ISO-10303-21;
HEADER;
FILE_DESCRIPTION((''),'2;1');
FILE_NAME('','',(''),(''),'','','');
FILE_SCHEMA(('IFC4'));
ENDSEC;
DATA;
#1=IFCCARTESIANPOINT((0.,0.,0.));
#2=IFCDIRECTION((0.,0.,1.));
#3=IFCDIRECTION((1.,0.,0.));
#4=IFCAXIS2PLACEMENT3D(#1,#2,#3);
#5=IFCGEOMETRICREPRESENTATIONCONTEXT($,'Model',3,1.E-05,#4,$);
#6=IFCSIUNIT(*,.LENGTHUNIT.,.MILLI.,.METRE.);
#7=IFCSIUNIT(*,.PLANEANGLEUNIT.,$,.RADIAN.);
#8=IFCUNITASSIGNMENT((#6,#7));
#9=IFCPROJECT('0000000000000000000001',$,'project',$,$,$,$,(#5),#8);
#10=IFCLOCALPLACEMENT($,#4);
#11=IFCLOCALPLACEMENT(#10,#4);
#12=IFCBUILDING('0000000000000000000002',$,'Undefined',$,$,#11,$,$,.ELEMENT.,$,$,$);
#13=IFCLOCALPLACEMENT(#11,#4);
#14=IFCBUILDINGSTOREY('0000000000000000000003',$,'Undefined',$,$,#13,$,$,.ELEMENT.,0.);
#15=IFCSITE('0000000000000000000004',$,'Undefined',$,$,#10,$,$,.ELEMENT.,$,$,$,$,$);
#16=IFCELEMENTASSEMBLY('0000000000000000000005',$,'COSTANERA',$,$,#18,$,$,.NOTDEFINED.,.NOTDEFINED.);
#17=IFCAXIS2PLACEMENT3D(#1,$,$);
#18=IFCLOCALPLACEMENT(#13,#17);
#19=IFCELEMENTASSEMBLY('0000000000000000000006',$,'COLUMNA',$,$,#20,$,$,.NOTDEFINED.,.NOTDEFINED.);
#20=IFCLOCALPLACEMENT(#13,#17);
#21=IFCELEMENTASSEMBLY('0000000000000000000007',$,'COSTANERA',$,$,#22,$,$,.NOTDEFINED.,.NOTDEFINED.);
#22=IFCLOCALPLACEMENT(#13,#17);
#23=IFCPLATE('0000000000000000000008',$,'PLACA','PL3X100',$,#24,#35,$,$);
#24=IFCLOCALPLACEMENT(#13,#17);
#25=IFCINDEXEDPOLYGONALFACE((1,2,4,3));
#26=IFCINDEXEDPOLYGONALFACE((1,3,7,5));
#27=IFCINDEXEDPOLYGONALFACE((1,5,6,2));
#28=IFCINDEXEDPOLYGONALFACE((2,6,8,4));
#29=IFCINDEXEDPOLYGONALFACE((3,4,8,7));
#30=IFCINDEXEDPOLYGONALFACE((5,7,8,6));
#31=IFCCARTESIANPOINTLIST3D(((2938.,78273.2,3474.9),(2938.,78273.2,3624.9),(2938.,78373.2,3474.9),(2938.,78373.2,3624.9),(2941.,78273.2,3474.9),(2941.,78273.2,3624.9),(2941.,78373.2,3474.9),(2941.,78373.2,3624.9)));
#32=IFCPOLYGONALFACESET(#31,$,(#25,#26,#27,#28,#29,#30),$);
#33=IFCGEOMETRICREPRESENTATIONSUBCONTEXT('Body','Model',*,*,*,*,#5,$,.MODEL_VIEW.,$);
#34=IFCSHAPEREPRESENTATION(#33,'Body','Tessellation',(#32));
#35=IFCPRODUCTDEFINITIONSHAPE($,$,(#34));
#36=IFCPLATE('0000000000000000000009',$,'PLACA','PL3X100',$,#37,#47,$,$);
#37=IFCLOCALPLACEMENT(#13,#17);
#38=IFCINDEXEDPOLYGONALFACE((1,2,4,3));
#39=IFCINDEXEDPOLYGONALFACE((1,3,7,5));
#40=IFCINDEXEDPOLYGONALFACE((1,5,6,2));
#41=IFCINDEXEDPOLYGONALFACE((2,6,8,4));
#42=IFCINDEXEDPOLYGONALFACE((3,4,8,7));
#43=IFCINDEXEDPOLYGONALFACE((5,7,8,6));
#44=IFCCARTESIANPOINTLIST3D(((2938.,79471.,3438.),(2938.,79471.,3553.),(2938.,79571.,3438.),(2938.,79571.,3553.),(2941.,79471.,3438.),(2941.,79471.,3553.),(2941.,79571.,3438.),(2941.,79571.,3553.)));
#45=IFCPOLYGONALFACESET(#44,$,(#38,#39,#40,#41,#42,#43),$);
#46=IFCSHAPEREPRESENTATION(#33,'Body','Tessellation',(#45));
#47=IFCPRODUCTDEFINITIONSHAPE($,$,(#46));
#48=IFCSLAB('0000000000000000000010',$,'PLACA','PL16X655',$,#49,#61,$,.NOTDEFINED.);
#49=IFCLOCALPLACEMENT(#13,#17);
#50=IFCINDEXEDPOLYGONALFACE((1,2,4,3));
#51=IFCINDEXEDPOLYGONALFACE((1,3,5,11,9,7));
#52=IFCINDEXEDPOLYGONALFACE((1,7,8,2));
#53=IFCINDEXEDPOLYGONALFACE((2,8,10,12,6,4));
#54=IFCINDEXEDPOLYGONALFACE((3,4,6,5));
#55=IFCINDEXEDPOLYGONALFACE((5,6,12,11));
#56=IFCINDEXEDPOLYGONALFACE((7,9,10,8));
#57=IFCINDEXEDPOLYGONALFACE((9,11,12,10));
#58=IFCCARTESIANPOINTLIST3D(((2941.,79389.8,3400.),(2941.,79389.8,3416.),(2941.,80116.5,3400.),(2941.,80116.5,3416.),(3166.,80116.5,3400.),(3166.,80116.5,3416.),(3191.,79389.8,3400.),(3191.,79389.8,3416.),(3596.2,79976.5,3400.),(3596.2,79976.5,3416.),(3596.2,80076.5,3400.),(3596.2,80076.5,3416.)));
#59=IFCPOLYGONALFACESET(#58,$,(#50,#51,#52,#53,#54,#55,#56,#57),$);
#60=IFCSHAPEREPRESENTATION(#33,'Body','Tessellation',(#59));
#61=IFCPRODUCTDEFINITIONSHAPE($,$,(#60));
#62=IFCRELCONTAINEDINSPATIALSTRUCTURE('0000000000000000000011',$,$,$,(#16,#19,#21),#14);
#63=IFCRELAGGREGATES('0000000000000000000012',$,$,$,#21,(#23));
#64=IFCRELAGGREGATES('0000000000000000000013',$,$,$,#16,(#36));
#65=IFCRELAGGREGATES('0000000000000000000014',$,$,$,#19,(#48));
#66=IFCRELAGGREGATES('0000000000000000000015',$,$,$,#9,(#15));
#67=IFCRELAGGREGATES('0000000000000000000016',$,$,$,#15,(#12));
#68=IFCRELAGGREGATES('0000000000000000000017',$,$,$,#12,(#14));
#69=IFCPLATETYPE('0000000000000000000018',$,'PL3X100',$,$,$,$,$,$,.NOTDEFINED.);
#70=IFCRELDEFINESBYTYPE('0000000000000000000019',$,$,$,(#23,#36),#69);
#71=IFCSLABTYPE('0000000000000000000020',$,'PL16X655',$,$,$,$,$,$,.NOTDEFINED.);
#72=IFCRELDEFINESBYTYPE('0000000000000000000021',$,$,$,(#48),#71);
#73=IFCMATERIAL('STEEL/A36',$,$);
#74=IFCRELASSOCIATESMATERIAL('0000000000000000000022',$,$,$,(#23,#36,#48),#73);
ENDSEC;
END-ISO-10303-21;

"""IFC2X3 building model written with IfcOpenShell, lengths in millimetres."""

from ifc_helpers import new_model, si_unit, frame, origin_with_axes, place, context, subcontext, project, spatial, polyline, outline, extrude, material, type_object, element, aggregate, save


model = new_model("IFC2X3")

# Units and contexts
model_context = context("Model", 3, precision=1e-05, world=origin_with_axes())
body_context = subcontext(model_context, "Body", "Model", "MODEL_VIEW")
ifc_project = project(units=[si_unit("LENGTHUNIT", "METRE", prefix="MILLI"), si_unit("PLANEANGLEUNIT", "RADIAN")], contexts=[model_context])

# Site, building, storey
site_placement = place(None, origin_with_axes())
site = spatial("IfcSite", under=ifc_project, at=site_placement, Name="Undefined", CompositionType="ELEMENT")
building_placement = place(site_placement, origin_with_axes())
building = spatial("IfcBuilding", under=site, at=building_placement, Name="Undefined", CompositionType="ELEMENT")
storey_placement = place(building_placement, origin_with_axes())
storey = spatial("IfcBuildingStorey", under=building, at=storey_placement, Name="Undefined", CompositionType="ELEMENT", Elevation=0.0)

# Element assembly
ifc_material_1 = material(Name="STEEL/A36")
assembly_1_placement = place(storey_placement, origin_with_axes())
assembly_1 = element("IfcElementAssembly", 1, at=assembly_1_placement, inside=storey, Name="COSTANERA", AssemblyPlace="NOTDEFINED", PredefinedType="NOTDEFINED")

# Element assembly
assembly_2_placement = place(storey_placement, origin_with_axes())
assembly_2 = element("IfcElementAssembly", 2, at=assembly_2_placement, inside=storey, Name="COLUMNA", AssemblyPlace="NOTDEFINED", PredefinedType="NOTDEFINED")

# Shared definitions
plate_type_1 = type_object("IfcPlateType", Name="PL3X100", PredefinedType="NOTDEFINED")

# Element assembly, plate
assembly_3_placement = place(storey_placement, origin_with_axes())
assembly_3 = element("IfcElementAssembly", 3, at=assembly_3_placement, inside=storey, Name="COSTANERA", AssemblyPlace="NOTDEFINED", PredefinedType="NOTDEFINED")
plate_1_placement = place(assembly_3_placement, frame((2939.5, 78273.2, 3474.9), z_axis=(1.0, 0.0, 0.0), x_axis=(0.0, 1.0, 0.0)))
plate_1 = element("IfcPlate", 4, at=plate_1_placement, type_object=plate_type_1, material=ifc_material_1, Name="PLACA", Description="PL3X100", context=body_context, shape_type="SweptSolid", body=[
    extrude(outline(polyline([(0.0, 0.0), (100.0, 0.0), (100.0, 150.0), (0.0, 150.0), (0.0, 0.0)])), frame((0.0, 0.0, -1.5), z_axis=(0.0, 0.0, 1.0), x_axis=(1.0, 0.0, 0.0)), (0.0, 0.0, 1.0), 3.0),
])
aggregate(assembly_3, [plate_1])

# Plate
plate_2_placement = place(assembly_1_placement, frame((2939.5, 79471.0, 3438.0), z_axis=(1.0, 0.0, 0.0), x_axis=(0.0, 1.0, 0.0)))
plate_2 = element("IfcPlate", 5, at=plate_2_placement, type_object=plate_type_1, material=ifc_material_1, Name="PLACA", Description="PL3X100", context=body_context, shape_type="SweptSolid", body=[
    extrude(outline(polyline([(0.0, 0.0), (100.0, 0.0), (100.0, 115.0), (0.0, 115.0), (0.0, 0.0)])), frame((0.0, 0.0, -1.5), z_axis=(0.0, 0.0, 1.0), x_axis=(1.0, 0.0, 0.0)), (0.0, 0.0, 1.0), 3.0),
])
aggregate(assembly_1, [plate_2])

# Slab
slab_type = type_object("IfcSlabType", Name="PL16X655", PredefinedType="NOTDEFINED")
slab_placement = place(assembly_2_placement, frame((3191.0, 79389.8, 3408.0), z_axis=(0.0, 0.0, 1.0), x_axis=(0.568291, 0.822828, 0.0)))
slab = element("IfcSlab", 6, at=slab_placement, type_object=slab_type, material=ifc_material_1, Name="PLACA", Description="PL16X655", PredefinedType="NOTDEFINED", context=body_context, shape_type="SweptSolid", body=[
    extrude(outline(polyline([(0.0, 0.0), (713.1, 0.0), (795.3, 56.8), (583.8, 433.6), (455.9, 618.7), (-142.1, 205.7), (0.0, 0.0)])), frame((0.0, 0.0, -8.0), z_axis=(0.0, 0.0, 1.0), x_axis=(1.0, 0.0, 0.0)), (0.0, 0.0, 1.0), 16.0),
])

aggregate(assembly_2, [slab])

save(model, "model.ifc")
